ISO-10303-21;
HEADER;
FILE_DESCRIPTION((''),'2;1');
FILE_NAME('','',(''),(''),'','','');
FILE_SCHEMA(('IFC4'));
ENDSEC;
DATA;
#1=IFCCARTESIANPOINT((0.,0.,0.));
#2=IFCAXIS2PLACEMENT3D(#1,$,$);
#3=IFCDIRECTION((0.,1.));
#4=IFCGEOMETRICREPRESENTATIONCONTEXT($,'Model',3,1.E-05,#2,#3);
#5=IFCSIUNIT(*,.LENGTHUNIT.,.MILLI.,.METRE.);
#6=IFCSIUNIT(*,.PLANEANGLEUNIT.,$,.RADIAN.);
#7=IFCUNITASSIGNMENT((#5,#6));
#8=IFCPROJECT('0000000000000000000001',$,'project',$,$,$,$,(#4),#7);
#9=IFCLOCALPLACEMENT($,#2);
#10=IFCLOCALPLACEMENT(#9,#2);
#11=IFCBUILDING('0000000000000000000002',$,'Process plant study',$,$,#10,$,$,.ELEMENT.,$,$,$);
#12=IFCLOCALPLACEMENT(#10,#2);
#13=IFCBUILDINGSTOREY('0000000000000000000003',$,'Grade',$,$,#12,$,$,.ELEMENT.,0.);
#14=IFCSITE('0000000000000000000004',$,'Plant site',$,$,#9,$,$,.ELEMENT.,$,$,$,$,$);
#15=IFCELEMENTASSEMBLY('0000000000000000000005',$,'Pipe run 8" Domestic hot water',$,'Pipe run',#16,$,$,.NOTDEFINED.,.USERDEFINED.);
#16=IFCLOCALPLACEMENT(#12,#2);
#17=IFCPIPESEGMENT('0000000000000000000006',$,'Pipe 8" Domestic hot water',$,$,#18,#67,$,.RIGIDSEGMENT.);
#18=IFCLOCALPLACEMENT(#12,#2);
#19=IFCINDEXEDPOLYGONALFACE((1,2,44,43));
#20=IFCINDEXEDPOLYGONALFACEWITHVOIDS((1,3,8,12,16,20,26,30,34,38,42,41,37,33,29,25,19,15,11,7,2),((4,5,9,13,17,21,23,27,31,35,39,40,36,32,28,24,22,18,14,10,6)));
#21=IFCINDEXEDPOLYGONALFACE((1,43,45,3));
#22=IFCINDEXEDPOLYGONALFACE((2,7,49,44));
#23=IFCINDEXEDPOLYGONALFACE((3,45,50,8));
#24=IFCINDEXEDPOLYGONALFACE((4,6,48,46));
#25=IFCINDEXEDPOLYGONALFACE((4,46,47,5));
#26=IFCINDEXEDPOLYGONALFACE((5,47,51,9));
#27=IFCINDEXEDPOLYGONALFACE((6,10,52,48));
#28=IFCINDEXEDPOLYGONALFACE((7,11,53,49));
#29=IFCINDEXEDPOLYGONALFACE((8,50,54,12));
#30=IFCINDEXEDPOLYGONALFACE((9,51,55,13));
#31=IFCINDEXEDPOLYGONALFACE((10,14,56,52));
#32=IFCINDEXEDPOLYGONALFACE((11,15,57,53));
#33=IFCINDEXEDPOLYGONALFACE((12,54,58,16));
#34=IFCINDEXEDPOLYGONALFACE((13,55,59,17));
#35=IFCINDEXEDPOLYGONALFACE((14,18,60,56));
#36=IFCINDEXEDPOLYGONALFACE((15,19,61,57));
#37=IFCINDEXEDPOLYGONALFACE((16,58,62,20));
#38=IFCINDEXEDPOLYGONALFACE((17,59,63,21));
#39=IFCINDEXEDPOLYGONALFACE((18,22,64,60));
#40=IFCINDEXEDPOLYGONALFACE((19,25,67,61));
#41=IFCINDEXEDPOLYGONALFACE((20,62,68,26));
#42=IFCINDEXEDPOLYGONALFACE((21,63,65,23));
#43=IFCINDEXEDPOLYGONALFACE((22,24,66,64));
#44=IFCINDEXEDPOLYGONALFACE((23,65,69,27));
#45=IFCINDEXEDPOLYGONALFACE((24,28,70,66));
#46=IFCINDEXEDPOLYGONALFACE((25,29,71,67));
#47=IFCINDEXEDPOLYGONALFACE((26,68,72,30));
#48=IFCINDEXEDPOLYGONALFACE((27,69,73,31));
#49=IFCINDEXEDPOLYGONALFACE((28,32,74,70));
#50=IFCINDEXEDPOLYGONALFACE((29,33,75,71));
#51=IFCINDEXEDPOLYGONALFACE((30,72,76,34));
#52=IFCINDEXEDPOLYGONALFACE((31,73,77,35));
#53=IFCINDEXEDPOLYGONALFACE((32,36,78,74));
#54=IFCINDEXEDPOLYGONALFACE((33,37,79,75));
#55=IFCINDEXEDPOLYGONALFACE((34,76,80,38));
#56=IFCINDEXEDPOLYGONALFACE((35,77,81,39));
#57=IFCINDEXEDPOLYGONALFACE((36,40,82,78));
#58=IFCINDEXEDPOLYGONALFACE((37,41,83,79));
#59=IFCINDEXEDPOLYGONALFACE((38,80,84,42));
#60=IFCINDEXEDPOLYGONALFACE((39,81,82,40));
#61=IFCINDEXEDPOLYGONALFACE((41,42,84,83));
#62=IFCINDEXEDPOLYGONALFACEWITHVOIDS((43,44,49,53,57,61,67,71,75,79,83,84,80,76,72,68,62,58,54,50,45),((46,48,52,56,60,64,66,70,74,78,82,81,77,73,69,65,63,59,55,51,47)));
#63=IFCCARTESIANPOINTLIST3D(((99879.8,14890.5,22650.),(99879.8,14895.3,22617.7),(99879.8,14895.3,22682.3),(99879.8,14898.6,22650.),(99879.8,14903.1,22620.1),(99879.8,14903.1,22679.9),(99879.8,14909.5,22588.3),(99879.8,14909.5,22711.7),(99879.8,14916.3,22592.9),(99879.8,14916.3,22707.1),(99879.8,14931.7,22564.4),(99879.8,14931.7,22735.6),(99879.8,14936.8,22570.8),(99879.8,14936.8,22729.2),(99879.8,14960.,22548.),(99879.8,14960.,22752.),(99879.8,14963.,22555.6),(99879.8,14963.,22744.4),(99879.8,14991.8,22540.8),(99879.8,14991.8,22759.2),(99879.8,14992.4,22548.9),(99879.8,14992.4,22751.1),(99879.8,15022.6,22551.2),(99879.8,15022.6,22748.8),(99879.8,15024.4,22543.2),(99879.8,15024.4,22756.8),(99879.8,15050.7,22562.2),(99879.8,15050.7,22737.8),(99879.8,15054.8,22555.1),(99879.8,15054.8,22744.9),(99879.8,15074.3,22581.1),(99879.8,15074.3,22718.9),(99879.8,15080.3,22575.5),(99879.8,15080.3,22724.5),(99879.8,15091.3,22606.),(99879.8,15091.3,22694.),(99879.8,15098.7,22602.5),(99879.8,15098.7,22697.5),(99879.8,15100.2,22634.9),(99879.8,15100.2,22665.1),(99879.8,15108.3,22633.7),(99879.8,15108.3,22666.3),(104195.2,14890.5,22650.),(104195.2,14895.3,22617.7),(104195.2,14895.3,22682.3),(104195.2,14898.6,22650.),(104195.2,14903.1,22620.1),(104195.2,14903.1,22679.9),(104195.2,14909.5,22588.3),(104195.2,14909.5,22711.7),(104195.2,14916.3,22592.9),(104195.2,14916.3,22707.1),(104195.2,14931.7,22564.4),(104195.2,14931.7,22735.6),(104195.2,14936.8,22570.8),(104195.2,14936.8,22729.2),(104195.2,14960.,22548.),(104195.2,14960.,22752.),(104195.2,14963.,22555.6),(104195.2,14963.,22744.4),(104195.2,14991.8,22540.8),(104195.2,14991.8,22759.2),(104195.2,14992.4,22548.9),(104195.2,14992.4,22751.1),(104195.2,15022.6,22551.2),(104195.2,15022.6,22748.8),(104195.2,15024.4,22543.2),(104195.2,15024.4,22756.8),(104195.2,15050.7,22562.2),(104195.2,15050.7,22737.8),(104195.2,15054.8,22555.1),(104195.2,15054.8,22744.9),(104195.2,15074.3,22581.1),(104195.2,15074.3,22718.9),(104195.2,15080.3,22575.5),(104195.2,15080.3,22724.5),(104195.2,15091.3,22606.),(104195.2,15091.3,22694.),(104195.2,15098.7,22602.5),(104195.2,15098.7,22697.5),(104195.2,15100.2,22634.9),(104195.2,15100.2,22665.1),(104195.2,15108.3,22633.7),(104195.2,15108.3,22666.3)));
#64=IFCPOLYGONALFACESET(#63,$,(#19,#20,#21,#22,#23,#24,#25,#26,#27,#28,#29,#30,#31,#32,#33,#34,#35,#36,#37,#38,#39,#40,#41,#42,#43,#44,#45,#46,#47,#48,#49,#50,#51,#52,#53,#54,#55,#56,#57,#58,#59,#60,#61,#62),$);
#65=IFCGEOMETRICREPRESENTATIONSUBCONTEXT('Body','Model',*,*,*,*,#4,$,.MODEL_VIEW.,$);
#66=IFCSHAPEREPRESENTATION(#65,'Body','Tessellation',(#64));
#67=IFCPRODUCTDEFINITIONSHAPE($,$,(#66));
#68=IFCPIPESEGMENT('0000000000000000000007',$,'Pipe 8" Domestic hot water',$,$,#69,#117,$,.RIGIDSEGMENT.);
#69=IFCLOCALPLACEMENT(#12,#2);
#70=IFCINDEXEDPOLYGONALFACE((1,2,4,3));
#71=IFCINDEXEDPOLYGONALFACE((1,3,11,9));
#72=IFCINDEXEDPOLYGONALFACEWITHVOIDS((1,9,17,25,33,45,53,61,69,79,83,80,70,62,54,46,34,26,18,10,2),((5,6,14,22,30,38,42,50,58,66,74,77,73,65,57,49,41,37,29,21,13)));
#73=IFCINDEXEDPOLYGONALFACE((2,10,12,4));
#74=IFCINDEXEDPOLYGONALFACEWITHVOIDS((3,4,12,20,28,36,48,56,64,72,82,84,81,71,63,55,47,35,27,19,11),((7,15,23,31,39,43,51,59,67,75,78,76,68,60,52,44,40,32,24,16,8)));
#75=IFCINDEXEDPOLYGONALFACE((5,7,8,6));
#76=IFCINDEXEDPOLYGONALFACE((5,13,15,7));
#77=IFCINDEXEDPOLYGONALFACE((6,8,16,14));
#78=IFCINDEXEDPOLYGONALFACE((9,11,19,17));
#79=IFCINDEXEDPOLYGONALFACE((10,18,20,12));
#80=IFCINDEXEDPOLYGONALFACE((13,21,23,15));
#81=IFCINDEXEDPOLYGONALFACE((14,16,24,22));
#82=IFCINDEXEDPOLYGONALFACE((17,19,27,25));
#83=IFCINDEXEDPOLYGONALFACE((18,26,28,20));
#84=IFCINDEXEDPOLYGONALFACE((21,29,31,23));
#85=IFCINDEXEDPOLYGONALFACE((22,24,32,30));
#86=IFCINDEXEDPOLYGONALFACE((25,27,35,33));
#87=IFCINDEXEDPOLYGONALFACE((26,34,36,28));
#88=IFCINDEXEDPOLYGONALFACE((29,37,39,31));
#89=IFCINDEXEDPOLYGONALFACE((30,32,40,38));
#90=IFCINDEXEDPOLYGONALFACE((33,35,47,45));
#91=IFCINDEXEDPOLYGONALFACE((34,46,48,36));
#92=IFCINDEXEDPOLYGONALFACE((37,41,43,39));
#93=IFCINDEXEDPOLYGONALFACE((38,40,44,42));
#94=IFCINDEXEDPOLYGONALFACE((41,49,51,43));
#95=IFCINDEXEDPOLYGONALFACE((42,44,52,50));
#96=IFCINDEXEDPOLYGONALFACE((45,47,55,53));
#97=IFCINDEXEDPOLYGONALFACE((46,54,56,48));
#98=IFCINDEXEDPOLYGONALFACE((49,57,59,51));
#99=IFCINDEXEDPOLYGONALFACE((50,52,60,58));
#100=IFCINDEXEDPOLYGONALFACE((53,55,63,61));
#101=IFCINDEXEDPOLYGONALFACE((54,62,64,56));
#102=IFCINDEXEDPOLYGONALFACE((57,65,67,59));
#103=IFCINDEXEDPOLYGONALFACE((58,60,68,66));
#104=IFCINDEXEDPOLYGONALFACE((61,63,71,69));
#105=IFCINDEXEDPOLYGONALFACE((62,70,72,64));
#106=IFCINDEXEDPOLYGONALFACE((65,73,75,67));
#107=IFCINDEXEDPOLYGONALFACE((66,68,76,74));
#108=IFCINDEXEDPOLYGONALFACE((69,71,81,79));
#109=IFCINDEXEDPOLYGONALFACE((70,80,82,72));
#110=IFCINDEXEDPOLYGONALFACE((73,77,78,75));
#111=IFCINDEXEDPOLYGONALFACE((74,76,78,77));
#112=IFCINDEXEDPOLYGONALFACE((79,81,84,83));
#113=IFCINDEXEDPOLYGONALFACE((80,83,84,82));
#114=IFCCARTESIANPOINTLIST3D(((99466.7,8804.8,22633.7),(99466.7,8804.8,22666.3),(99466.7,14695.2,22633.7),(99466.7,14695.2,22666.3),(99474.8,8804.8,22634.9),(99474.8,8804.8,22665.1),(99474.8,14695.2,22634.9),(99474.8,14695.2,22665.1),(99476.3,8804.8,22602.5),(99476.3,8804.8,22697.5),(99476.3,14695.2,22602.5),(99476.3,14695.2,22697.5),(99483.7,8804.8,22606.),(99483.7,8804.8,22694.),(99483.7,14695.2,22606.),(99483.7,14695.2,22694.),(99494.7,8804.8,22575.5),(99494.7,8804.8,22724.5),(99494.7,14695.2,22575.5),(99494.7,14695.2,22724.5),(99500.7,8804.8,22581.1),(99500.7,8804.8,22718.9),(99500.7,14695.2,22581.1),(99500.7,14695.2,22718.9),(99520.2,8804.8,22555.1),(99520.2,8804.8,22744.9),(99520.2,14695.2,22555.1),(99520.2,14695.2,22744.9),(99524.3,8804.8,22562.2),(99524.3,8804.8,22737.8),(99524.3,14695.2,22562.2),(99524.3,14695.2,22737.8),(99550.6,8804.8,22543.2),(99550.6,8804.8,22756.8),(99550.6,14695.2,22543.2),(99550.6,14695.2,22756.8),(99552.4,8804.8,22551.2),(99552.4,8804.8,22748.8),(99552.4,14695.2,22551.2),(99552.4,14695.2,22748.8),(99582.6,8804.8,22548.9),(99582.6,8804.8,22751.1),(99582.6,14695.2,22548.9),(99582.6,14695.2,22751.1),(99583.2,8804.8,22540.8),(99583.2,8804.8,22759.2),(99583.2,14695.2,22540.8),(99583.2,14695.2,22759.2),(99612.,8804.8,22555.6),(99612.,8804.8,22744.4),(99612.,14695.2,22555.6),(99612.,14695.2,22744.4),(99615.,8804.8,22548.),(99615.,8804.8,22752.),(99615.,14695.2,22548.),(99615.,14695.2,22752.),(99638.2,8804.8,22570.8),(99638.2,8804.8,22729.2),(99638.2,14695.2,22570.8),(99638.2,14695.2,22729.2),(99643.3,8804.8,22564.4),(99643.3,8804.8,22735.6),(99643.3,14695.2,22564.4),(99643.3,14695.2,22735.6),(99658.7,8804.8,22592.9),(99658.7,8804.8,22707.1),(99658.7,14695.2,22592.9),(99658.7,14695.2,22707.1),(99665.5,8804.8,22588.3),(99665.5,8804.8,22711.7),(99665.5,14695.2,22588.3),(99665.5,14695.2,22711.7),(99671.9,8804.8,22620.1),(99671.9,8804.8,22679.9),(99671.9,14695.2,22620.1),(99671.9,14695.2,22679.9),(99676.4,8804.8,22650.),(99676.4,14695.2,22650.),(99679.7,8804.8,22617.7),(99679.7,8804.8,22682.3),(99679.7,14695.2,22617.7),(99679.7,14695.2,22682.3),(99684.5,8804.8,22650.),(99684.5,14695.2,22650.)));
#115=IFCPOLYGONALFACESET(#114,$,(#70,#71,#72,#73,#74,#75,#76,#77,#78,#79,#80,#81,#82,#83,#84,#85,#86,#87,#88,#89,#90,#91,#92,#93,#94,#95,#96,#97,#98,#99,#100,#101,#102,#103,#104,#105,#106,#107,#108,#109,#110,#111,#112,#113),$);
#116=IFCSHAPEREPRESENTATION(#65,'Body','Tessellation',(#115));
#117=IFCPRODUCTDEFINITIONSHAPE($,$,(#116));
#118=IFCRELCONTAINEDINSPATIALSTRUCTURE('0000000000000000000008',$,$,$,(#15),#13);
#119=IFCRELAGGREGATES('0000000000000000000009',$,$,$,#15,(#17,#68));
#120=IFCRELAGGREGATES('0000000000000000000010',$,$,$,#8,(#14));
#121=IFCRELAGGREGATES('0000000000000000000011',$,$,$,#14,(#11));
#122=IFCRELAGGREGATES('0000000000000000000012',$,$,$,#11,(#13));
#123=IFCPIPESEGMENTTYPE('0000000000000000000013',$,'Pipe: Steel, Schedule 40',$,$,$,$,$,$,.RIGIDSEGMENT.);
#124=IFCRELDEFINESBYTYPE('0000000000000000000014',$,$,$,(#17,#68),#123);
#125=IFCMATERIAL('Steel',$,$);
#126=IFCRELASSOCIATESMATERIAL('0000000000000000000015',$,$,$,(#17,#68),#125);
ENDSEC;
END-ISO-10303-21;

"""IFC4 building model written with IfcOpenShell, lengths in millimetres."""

from ifc_helpers import new_model, si_unit, direction, frame, origin, origin_with_axes, origin_2d, place, context, subcontext, project, spatial, hollow_circle, extrude, material, type_object, element, aggregate, save


model = new_model("IFC4")

# Units and contexts
model_context = context("Model", 3, precision=1e-05, world=origin(), true_north=direction((0.0, 1.0)))
body_context = subcontext(model_context, "Body", "Model", "MODEL_VIEW")
ifc_project = project(units=[si_unit("LENGTHUNIT", "METRE", prefix="MILLI"), si_unit("PLANEANGLEUNIT", "RADIAN")], contexts=[model_context])

# Site, building, storey
site_placement = place(None, origin())
site = spatial("IfcSite", under=ifc_project, at=site_placement, Name="Plant site", CompositionType="ELEMENT")
building_placement = place(site_placement, origin())
building = spatial("IfcBuilding", under=site, at=building_placement, Name="Process plant study", CompositionType="ELEMENT")
storey_placement = place(building_placement, origin())
storey = spatial("IfcBuildingStorey", under=building, at=storey_placement, Name="Grade", CompositionType="ELEMENT", Elevation=0.0)

# Element assembly, pipe segments
ifc_material = material(Name="Steel")
pipe_segment_type = type_object("IfcPipeSegmentType", Name="Pipe: Steel, Schedule 40", PredefinedType="RIGIDSEGMENT")
assembly_1_placement = place(storey_placement, origin_with_axes())
assembly_1 = element("IfcElementAssembly", 1, at=assembly_1_placement, inside=storey, Name="Pipe run 8\" Domestic hot water", ObjectType="Pipe run", AssemblyPlace="NOTDEFINED", PredefinedType="USERDEFINED")
pipe_segment_1_placement = place(storey_placement, origin_with_axes())
pipe_segment_1 = element("IfcPipeSegment", 2, at=pipe_segment_1_placement, type_object=pipe_segment_type, material=ifc_material, Name="Pipe 8\" Domestic hot water", PredefinedType="RIGIDSEGMENT", context=body_context, shape_type="SweptSolid", body=[
    extrude(hollow_circle(Radius=109.5, WallThickness=8.2, at=origin_2d()), frame((104195.2, 15000.0, 22650.0), z_axis=(-1.0, 0.0, 0.0), x_axis=(0.0, -1.0, 0.0)), (0.0, 0.0, 1.0), 4315.4),
])
pipe_segment_2_placement = place(storey_placement, origin_with_axes())
pipe_segment_2 = element("IfcPipeSegment", 3, at=pipe_segment_2_placement, type_object=pipe_segment_type, material=ifc_material, Name="Pipe 8\" Domestic hot water", PredefinedType="RIGIDSEGMENT", context=body_context, shape_type="SweptSolid", body=[
    extrude(hollow_circle(Radius=109.5, WallThickness=8.2, at=origin_2d()), frame((99575.0, 14695.2, 22650.0), z_axis=(0.0, -1.0, 0.0), x_axis=(1.0, 0.0, 0.0)), (0.0, 0.0, 1.0), 5890.4),
])

aggregate(assembly_1, [pipe_segment_1, pipe_segment_2])

save(model, "model.ifc")
